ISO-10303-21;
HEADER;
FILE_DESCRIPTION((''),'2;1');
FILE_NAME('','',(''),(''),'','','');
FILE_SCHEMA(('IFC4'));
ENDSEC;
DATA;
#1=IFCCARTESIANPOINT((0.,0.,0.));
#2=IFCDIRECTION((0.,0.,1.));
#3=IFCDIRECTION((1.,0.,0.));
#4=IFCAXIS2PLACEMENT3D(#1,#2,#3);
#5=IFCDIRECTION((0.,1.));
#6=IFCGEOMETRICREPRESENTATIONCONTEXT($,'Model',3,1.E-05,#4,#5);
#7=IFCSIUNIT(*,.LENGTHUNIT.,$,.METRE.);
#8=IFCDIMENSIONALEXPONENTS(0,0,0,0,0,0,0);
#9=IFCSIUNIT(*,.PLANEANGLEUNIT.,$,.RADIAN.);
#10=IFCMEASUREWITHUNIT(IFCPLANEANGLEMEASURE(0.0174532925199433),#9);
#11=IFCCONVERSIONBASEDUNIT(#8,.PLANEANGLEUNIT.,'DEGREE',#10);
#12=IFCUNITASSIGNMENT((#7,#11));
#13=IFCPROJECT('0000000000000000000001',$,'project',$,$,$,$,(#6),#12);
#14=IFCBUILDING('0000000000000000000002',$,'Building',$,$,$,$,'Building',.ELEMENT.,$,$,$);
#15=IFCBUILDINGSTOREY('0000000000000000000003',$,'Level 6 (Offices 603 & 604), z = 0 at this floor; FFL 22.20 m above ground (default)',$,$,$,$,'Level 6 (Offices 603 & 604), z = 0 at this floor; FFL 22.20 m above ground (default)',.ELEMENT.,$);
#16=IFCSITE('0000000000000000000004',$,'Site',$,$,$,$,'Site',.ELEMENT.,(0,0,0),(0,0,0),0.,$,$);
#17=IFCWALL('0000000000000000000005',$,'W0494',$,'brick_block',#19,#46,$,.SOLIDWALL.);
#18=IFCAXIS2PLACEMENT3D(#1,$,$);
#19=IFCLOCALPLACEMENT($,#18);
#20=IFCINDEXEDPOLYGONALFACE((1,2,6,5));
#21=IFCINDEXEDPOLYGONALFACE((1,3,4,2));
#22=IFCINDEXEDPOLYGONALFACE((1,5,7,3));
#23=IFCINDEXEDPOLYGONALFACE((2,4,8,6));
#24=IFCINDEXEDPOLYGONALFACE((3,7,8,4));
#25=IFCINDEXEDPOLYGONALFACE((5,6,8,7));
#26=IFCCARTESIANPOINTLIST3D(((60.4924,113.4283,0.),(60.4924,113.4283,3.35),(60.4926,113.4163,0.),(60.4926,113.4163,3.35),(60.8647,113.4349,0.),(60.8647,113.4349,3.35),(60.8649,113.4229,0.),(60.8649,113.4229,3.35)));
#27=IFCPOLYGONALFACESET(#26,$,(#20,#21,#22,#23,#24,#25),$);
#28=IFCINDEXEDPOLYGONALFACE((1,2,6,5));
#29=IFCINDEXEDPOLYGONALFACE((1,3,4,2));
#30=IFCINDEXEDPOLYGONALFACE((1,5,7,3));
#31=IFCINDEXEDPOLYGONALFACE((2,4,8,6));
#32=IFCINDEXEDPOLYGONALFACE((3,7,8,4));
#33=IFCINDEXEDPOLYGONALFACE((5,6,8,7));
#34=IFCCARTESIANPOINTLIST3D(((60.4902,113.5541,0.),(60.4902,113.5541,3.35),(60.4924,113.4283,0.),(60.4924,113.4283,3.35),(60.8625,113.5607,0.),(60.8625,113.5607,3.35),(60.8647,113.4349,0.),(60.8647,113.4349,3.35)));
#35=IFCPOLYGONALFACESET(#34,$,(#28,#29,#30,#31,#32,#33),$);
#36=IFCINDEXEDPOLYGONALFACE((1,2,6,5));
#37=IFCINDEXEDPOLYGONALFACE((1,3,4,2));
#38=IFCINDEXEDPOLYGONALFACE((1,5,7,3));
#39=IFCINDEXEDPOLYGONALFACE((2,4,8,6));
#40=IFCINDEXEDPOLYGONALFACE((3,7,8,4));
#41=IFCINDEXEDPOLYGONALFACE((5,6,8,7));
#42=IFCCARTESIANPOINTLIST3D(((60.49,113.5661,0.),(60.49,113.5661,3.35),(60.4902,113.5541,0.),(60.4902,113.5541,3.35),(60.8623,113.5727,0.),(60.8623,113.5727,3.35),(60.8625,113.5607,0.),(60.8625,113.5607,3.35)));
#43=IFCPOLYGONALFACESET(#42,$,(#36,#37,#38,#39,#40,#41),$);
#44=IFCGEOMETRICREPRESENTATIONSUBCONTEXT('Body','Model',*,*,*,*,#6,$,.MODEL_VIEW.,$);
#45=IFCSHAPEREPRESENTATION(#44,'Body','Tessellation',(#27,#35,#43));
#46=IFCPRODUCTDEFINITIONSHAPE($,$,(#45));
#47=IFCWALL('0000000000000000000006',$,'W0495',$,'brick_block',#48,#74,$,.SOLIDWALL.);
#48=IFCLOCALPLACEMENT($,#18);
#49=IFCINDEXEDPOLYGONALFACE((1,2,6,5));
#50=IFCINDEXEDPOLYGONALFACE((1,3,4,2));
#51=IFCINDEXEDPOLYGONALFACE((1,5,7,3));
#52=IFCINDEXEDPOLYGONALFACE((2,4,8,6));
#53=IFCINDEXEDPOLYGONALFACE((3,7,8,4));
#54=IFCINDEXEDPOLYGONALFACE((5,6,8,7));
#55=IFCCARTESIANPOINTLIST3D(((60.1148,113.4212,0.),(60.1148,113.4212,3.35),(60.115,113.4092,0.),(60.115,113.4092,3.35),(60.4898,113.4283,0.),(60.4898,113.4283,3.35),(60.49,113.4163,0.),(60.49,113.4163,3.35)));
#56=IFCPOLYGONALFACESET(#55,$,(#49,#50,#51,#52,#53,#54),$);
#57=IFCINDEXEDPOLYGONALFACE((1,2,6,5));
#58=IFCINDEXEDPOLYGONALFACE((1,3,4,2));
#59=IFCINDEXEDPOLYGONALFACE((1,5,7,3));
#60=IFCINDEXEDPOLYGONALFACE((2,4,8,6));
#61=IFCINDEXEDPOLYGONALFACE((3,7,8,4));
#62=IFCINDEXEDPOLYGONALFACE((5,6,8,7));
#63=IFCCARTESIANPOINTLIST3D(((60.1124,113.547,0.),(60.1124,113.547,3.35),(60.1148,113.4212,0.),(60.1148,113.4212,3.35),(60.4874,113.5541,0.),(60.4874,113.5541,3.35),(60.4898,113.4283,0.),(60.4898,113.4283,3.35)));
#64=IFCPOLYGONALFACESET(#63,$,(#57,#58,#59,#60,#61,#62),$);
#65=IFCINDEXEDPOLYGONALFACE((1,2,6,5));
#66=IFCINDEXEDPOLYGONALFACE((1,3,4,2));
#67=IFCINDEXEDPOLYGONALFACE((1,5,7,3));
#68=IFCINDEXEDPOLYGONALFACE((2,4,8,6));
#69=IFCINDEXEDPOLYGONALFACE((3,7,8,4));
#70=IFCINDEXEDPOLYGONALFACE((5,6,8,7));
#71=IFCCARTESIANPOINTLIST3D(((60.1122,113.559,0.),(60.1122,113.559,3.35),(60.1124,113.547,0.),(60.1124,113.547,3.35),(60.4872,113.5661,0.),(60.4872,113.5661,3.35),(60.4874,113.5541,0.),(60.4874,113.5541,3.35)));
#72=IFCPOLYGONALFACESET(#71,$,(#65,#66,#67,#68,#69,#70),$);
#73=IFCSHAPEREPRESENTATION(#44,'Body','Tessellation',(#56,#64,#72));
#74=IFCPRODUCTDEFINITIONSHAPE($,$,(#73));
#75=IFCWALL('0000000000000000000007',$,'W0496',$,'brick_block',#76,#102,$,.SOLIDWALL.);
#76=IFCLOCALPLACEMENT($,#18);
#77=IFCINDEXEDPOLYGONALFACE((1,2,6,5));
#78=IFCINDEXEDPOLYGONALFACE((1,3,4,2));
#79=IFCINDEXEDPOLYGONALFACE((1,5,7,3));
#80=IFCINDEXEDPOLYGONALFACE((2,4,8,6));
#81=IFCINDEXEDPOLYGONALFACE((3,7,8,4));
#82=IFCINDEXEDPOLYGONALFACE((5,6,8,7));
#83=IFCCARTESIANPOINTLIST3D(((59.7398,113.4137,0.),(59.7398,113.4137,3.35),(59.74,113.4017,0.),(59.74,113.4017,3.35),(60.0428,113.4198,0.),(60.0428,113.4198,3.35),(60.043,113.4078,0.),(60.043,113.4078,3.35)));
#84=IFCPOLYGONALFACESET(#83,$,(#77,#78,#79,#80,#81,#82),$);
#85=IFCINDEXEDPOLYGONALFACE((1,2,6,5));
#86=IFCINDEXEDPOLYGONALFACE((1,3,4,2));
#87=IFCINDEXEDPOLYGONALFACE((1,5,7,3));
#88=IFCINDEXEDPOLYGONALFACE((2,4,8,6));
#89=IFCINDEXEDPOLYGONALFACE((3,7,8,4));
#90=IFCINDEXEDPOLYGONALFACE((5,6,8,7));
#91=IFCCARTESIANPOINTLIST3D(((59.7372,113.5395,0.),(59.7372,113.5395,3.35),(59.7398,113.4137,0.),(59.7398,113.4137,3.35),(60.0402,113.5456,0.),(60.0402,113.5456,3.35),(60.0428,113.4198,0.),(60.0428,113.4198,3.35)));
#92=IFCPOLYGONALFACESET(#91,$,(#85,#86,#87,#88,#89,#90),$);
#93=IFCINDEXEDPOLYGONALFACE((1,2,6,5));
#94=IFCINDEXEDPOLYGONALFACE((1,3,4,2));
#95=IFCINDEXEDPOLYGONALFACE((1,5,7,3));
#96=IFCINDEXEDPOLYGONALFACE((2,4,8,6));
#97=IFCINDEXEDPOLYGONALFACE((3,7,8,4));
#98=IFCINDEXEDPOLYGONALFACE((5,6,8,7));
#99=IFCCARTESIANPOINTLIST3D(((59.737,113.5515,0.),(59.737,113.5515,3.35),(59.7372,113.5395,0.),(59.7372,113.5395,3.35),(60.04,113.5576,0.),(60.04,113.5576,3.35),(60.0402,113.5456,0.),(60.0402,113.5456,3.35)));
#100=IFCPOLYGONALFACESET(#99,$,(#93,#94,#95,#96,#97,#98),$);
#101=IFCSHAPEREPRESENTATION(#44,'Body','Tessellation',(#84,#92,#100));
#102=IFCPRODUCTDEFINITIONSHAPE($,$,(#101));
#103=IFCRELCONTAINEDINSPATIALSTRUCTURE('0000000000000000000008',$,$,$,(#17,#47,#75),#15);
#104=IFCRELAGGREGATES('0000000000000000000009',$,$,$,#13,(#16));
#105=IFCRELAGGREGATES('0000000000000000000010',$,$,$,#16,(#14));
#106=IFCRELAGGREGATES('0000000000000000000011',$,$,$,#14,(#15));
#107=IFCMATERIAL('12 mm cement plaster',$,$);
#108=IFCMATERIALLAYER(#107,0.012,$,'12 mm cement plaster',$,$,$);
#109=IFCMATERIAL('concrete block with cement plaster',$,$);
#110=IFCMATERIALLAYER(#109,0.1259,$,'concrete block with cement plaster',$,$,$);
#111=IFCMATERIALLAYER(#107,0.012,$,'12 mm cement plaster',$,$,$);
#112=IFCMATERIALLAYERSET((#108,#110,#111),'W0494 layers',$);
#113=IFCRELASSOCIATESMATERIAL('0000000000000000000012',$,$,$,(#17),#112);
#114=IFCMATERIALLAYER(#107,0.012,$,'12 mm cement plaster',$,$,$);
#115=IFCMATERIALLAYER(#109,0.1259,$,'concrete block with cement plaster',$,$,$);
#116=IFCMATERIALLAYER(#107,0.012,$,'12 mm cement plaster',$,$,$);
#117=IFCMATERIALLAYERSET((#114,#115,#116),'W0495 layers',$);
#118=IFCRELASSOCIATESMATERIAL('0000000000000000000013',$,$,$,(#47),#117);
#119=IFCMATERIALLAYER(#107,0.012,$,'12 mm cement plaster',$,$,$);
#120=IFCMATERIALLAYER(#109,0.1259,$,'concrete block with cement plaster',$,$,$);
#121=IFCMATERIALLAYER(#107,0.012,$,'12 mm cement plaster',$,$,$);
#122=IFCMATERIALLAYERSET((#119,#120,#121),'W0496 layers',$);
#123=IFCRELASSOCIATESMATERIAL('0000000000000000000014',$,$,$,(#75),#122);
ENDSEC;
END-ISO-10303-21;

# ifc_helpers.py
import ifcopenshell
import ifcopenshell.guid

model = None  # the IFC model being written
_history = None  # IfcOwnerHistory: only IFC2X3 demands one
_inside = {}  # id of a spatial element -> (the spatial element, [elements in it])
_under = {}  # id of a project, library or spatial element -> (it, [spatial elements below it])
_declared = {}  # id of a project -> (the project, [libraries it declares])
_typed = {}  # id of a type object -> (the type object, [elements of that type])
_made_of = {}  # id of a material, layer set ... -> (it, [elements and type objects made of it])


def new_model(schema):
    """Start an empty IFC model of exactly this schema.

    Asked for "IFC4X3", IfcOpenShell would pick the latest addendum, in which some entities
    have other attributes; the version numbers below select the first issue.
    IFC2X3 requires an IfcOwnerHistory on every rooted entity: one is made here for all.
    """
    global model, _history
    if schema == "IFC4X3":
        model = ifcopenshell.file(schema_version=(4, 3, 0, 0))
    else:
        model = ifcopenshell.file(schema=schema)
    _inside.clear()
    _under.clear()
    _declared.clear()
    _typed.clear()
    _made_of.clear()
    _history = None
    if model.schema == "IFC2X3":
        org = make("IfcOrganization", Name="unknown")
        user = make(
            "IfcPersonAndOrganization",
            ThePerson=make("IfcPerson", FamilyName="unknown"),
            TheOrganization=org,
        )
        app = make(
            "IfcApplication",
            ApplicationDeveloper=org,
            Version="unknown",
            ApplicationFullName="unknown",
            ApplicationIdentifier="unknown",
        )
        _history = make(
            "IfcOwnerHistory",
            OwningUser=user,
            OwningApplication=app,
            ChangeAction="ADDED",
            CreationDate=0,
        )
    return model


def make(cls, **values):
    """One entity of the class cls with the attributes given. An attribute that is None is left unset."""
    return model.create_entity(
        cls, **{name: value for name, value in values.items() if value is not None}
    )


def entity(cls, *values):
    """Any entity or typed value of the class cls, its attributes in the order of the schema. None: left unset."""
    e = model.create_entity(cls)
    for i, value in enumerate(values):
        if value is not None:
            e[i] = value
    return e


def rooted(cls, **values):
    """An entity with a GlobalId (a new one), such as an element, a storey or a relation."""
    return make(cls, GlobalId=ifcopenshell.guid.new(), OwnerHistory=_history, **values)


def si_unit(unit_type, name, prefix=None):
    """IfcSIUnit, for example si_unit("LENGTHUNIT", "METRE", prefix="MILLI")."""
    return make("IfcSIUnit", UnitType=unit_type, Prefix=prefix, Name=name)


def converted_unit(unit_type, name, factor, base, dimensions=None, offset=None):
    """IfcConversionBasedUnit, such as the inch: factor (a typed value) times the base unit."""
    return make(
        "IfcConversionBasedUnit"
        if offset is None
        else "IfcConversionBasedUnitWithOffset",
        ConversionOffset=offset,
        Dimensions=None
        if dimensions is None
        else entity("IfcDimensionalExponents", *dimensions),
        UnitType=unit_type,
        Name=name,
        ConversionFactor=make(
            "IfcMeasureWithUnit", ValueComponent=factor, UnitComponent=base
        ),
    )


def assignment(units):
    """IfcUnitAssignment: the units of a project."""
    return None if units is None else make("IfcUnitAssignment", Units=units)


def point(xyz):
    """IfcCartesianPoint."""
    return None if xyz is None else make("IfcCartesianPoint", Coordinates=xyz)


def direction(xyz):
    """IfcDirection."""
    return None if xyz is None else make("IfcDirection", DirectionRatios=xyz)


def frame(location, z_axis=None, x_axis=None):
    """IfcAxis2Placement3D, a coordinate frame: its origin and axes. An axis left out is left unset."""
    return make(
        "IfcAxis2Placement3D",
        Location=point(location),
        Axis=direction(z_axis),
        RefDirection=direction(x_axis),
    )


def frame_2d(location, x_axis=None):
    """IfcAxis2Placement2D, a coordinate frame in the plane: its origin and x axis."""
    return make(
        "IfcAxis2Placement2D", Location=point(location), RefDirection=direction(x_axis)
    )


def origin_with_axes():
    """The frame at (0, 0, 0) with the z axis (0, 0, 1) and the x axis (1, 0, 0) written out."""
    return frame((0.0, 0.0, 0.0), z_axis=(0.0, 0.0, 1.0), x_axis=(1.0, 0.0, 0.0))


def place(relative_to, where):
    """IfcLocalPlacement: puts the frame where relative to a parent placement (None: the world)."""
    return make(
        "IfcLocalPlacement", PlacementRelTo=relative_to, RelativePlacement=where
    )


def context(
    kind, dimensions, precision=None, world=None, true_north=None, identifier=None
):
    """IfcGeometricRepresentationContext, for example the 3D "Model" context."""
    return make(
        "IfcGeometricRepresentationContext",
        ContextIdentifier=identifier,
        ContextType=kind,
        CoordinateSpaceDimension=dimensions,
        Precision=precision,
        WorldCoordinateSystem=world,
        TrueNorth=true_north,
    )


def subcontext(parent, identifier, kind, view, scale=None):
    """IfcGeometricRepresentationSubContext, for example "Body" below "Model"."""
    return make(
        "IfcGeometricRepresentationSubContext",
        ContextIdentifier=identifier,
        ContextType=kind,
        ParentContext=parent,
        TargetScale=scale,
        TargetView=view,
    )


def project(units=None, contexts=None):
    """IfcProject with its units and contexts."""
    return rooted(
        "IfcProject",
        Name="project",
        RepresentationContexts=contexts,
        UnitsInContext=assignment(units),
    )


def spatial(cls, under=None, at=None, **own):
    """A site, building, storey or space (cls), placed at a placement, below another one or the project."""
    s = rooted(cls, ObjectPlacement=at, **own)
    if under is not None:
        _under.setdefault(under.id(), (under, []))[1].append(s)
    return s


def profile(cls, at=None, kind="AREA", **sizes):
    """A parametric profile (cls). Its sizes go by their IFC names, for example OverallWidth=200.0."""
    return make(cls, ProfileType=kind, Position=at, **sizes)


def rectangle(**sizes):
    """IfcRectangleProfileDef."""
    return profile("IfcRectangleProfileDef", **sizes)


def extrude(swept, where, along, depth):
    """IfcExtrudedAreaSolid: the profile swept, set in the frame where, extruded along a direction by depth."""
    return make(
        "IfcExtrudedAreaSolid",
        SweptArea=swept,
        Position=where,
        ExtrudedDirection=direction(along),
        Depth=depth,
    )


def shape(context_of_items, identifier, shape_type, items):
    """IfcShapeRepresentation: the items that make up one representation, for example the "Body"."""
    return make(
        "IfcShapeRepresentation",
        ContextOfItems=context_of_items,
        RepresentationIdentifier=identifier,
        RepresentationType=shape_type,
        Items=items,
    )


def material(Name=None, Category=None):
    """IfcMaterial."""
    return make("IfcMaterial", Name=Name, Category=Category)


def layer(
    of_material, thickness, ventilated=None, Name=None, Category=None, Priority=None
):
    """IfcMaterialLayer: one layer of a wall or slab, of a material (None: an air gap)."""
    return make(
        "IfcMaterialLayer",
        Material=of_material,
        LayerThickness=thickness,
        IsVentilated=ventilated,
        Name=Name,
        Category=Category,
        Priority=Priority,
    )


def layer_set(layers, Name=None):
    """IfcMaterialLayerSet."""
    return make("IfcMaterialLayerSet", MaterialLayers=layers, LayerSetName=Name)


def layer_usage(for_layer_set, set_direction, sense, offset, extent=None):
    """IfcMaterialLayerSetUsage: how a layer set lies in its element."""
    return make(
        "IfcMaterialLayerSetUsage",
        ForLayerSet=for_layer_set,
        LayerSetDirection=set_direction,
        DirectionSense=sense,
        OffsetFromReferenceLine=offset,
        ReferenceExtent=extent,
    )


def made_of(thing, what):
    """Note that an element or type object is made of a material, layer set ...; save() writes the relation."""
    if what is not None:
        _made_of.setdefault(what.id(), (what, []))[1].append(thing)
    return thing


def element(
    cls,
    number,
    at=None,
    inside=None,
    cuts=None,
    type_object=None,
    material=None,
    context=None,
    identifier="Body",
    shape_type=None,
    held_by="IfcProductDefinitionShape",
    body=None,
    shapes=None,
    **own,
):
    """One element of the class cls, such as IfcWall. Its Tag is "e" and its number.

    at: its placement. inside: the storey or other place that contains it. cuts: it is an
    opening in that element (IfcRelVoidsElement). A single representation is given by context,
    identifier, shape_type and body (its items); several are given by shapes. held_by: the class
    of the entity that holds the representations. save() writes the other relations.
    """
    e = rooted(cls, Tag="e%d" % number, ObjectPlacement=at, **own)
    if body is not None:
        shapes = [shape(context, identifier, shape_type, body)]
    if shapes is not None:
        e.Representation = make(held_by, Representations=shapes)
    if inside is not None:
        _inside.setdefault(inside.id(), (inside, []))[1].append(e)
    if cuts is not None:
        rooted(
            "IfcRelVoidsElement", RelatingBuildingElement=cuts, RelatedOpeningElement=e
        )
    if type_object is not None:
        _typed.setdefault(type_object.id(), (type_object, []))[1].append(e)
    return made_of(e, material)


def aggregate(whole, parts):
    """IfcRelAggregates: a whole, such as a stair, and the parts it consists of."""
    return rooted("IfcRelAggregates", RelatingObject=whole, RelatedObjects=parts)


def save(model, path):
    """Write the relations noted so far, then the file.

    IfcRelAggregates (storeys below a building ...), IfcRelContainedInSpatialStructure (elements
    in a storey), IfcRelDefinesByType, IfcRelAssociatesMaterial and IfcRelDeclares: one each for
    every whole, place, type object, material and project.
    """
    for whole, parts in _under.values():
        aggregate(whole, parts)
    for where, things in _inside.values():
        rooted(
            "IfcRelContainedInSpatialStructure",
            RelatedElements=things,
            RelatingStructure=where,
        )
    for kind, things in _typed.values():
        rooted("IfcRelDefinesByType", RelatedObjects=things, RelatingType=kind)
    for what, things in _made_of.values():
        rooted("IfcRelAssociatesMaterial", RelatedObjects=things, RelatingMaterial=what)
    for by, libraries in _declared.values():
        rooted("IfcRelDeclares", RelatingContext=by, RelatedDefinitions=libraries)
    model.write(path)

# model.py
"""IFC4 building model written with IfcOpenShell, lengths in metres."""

from ifc_helpers import new_model, entity, si_unit, converted_unit, direction, frame, frame_2d, origin_with_axes, place, context, subcontext, project, spatial, rectangle, extrude, material, layer, layer_set, layer_usage, element, save


model = new_model("IFC4")

# Units and contexts
model_context = context("Model", 3, precision=1e-05, world=origin_with_axes(), true_north=direction((0.0, 1.0)))
body_context = subcontext(model_context, "Body", "Model", "MODEL_VIEW")
ifc_project = project(units=[si_unit("LENGTHUNIT", "METRE"), converted_unit("PLANEANGLEUNIT", "DEGREE", entity("IfcPlaneAngleMeasure", 0.0174532925199433), si_unit("PLANEANGLEUNIT", "RADIAN"), dimensions=[0, 0, 0, 0, 0, 0, 0])], contexts=[model_context])

# Site, building, storey
site = spatial("IfcSite", under=ifc_project, Name="Site", LongName="Site", CompositionType="ELEMENT", RefLatitude=(0, 0, 0), RefLongitude=(0, 0, 0), RefElevation=0.0)
building = spatial("IfcBuilding", under=site, Name="Building", LongName="Building", CompositionType="ELEMENT")
storey = spatial("IfcBuildingStorey", under=building, Name="Level 6 (Offices 603 & 604), z = 0 at this floor; FFL 22.20 m above ground (default)", LongName="Level 6 (Offices 603 & 604), z = 0 at this floor; FFL 22.20 m above ground (default)", CompositionType="ELEMENT")

# Walls
placement = place(None, origin_with_axes())
ifc_material_1 = material(Name="12 mm cement plaster")
ifc_material_2 = material(Name="concrete block with cement plaster")
ifc_layer_1 = layer(ifc_material_1, 0.012, Name="12 mm cement plaster")
ifc_layer_2 = layer(ifc_material_2, 0.1259, Name="concrete block with cement plaster")
ifc_layer_3 = layer(ifc_material_1, 0.012, Name="12 mm cement plaster")
ifc_layer_set_1 = layer_set([ifc_layer_1, ifc_layer_2, ifc_layer_3], Name="W0494 layers")
ifc_layer_usage_1 = layer_usage(ifc_layer_set_1, "AXIS2", "POSITIVE", -0.075)
element("IfcWall", 1, at=placement, inside=storey, material=ifc_layer_usage_1, Name="W0494", ObjectType="brick_block", PredefinedType="SOLIDWALL", context=body_context, shape_type="SweptSolid", body=[
    extrude(rectangle(XDim=0.3724, YDim=0.012, at=frame_2d((0.0, 0.0), x_axis=(0.999843, 0.017725))), frame((60.6787, 113.4256, 0.0), z_axis=(0.0, 0.0, 1.0), x_axis=(1.0, 0.0, 0.0)), (0.0, 0.0, 1.0), 3.35),
    extrude(rectangle(XDim=0.3724, YDim=0.1259, at=frame_2d((-0.0012, 0.0689), x_axis=(0.999843, 0.017725))), frame((60.6787, 113.4256, 0.0), z_axis=(0.0, 0.0, 1.0), x_axis=(1.0, 0.0, 0.0)), (0.0, 0.0, 1.0), 3.35),
    extrude(rectangle(XDim=0.3724, YDim=0.012, at=frame_2d((-0.0024, 0.1379), x_axis=(0.999843, 0.017725))), frame((60.6787, 113.4256, 0.0), z_axis=(0.0, 0.0, 1.0), x_axis=(1.0, 0.0, 0.0)), (0.0, 0.0, 1.0), 3.35),
])
ifc_layer_4 = layer(ifc_material_1, 0.012, Name="12 mm cement plaster")
ifc_layer_5 = layer(ifc_material_2, 0.1259, Name="concrete block with cement plaster")
ifc_layer_6 = layer(ifc_material_1, 0.012, Name="12 mm cement plaster")
ifc_layer_set_2 = layer_set([ifc_layer_4, ifc_layer_5, ifc_layer_6], Name="W0495 layers")
ifc_layer_usage_2 = layer_usage(ifc_layer_set_2, "AXIS2", "POSITIVE", -0.075)
element("IfcWall", 2, at=placement, inside=storey, material=ifc_layer_usage_2, Name="W0495", ObjectType="brick_block", PredefinedType="SOLIDWALL", context=body_context, shape_type="SweptSolid", body=[
    extrude(rectangle(XDim=0.3751, YDim=0.012, at=frame_2d((0.0, 0.0), x_axis=(0.999821, 0.01893))), frame((60.3024, 113.4187, 0.0), z_axis=(0.0, 0.0, 1.0), x_axis=(1.0, 0.0, 0.0)), (0.0, 0.0, 1.0), 3.35),
    extrude(rectangle(XDim=0.3751, YDim=0.1259, at=frame_2d((-0.0013, 0.0689), x_axis=(0.999821, 0.01893))), frame((60.3024, 113.4187, 0.0), z_axis=(0.0, 0.0, 1.0), x_axis=(1.0, 0.0, 0.0)), (0.0, 0.0, 1.0), 3.35),
    extrude(rectangle(XDim=0.3751, YDim=0.012, at=frame_2d((-0.0026, 0.1379), x_axis=(0.999821, 0.01893))), frame((60.3024, 113.4187, 0.0), z_axis=(0.0, 0.0, 1.0), x_axis=(1.0, 0.0, 0.0)), (0.0, 0.0, 1.0), 3.35),
])
ifc_layer_7 = layer(ifc_material_1, 0.012, Name="12 mm cement plaster")
ifc_layer_8 = layer(ifc_material_2, 0.1259, Name="concrete block with cement plaster")
ifc_layer_9 = layer(ifc_material_1, 0.012, Name="12 mm cement plaster")
ifc_layer_set_3 = layer_set([ifc_layer_7, ifc_layer_8, ifc_layer_9], Name="W0496 layers")
ifc_layer_usage_3 = layer_usage(ifc_layer_set_3, "AXIS2", "POSITIVE", -0.075)
element("IfcWall", 3, at=placement, inside=storey, material=ifc_layer_usage_3, Name="W0496", ObjectType="brick_block", PredefinedType="SOLIDWALL", context=body_context, shape_type="SweptSolid", body=[
    extrude(rectangle(XDim=0.3031, YDim=0.012, at=frame_2d((0.0, 0.0), x_axis=(0.999797, 0.020128))), frame((59.8914, 113.4107, 0.0), z_axis=(0.0, 0.0, 1.0), x_axis=(1.0, 0.0, 0.0)), (0.0, 0.0, 1.0), 3.35),
    extrude(rectangle(XDim=0.3031, YDim=0.1259, at=frame_2d((-0.0014, 0.0689), x_axis=(0.999797, 0.020128))), frame((59.8914, 113.4107, 0.0), z_axis=(0.0, 0.0, 1.0), x_axis=(1.0, 0.0, 0.0)), (0.0, 0.0, 1.0), 3.35),
    extrude(rectangle(XDim=0.3031, YDim=0.012, at=frame_2d((-0.0028, 0.1379), x_axis=(0.999797, 0.020128))), frame((59.8914, 113.4107, 0.0), z_axis=(0.0, 0.0, 1.0), x_axis=(1.0, 0.0, 0.0)), (0.0, 0.0, 1.0), 3.35),
])

save(model, "model.ifc")
